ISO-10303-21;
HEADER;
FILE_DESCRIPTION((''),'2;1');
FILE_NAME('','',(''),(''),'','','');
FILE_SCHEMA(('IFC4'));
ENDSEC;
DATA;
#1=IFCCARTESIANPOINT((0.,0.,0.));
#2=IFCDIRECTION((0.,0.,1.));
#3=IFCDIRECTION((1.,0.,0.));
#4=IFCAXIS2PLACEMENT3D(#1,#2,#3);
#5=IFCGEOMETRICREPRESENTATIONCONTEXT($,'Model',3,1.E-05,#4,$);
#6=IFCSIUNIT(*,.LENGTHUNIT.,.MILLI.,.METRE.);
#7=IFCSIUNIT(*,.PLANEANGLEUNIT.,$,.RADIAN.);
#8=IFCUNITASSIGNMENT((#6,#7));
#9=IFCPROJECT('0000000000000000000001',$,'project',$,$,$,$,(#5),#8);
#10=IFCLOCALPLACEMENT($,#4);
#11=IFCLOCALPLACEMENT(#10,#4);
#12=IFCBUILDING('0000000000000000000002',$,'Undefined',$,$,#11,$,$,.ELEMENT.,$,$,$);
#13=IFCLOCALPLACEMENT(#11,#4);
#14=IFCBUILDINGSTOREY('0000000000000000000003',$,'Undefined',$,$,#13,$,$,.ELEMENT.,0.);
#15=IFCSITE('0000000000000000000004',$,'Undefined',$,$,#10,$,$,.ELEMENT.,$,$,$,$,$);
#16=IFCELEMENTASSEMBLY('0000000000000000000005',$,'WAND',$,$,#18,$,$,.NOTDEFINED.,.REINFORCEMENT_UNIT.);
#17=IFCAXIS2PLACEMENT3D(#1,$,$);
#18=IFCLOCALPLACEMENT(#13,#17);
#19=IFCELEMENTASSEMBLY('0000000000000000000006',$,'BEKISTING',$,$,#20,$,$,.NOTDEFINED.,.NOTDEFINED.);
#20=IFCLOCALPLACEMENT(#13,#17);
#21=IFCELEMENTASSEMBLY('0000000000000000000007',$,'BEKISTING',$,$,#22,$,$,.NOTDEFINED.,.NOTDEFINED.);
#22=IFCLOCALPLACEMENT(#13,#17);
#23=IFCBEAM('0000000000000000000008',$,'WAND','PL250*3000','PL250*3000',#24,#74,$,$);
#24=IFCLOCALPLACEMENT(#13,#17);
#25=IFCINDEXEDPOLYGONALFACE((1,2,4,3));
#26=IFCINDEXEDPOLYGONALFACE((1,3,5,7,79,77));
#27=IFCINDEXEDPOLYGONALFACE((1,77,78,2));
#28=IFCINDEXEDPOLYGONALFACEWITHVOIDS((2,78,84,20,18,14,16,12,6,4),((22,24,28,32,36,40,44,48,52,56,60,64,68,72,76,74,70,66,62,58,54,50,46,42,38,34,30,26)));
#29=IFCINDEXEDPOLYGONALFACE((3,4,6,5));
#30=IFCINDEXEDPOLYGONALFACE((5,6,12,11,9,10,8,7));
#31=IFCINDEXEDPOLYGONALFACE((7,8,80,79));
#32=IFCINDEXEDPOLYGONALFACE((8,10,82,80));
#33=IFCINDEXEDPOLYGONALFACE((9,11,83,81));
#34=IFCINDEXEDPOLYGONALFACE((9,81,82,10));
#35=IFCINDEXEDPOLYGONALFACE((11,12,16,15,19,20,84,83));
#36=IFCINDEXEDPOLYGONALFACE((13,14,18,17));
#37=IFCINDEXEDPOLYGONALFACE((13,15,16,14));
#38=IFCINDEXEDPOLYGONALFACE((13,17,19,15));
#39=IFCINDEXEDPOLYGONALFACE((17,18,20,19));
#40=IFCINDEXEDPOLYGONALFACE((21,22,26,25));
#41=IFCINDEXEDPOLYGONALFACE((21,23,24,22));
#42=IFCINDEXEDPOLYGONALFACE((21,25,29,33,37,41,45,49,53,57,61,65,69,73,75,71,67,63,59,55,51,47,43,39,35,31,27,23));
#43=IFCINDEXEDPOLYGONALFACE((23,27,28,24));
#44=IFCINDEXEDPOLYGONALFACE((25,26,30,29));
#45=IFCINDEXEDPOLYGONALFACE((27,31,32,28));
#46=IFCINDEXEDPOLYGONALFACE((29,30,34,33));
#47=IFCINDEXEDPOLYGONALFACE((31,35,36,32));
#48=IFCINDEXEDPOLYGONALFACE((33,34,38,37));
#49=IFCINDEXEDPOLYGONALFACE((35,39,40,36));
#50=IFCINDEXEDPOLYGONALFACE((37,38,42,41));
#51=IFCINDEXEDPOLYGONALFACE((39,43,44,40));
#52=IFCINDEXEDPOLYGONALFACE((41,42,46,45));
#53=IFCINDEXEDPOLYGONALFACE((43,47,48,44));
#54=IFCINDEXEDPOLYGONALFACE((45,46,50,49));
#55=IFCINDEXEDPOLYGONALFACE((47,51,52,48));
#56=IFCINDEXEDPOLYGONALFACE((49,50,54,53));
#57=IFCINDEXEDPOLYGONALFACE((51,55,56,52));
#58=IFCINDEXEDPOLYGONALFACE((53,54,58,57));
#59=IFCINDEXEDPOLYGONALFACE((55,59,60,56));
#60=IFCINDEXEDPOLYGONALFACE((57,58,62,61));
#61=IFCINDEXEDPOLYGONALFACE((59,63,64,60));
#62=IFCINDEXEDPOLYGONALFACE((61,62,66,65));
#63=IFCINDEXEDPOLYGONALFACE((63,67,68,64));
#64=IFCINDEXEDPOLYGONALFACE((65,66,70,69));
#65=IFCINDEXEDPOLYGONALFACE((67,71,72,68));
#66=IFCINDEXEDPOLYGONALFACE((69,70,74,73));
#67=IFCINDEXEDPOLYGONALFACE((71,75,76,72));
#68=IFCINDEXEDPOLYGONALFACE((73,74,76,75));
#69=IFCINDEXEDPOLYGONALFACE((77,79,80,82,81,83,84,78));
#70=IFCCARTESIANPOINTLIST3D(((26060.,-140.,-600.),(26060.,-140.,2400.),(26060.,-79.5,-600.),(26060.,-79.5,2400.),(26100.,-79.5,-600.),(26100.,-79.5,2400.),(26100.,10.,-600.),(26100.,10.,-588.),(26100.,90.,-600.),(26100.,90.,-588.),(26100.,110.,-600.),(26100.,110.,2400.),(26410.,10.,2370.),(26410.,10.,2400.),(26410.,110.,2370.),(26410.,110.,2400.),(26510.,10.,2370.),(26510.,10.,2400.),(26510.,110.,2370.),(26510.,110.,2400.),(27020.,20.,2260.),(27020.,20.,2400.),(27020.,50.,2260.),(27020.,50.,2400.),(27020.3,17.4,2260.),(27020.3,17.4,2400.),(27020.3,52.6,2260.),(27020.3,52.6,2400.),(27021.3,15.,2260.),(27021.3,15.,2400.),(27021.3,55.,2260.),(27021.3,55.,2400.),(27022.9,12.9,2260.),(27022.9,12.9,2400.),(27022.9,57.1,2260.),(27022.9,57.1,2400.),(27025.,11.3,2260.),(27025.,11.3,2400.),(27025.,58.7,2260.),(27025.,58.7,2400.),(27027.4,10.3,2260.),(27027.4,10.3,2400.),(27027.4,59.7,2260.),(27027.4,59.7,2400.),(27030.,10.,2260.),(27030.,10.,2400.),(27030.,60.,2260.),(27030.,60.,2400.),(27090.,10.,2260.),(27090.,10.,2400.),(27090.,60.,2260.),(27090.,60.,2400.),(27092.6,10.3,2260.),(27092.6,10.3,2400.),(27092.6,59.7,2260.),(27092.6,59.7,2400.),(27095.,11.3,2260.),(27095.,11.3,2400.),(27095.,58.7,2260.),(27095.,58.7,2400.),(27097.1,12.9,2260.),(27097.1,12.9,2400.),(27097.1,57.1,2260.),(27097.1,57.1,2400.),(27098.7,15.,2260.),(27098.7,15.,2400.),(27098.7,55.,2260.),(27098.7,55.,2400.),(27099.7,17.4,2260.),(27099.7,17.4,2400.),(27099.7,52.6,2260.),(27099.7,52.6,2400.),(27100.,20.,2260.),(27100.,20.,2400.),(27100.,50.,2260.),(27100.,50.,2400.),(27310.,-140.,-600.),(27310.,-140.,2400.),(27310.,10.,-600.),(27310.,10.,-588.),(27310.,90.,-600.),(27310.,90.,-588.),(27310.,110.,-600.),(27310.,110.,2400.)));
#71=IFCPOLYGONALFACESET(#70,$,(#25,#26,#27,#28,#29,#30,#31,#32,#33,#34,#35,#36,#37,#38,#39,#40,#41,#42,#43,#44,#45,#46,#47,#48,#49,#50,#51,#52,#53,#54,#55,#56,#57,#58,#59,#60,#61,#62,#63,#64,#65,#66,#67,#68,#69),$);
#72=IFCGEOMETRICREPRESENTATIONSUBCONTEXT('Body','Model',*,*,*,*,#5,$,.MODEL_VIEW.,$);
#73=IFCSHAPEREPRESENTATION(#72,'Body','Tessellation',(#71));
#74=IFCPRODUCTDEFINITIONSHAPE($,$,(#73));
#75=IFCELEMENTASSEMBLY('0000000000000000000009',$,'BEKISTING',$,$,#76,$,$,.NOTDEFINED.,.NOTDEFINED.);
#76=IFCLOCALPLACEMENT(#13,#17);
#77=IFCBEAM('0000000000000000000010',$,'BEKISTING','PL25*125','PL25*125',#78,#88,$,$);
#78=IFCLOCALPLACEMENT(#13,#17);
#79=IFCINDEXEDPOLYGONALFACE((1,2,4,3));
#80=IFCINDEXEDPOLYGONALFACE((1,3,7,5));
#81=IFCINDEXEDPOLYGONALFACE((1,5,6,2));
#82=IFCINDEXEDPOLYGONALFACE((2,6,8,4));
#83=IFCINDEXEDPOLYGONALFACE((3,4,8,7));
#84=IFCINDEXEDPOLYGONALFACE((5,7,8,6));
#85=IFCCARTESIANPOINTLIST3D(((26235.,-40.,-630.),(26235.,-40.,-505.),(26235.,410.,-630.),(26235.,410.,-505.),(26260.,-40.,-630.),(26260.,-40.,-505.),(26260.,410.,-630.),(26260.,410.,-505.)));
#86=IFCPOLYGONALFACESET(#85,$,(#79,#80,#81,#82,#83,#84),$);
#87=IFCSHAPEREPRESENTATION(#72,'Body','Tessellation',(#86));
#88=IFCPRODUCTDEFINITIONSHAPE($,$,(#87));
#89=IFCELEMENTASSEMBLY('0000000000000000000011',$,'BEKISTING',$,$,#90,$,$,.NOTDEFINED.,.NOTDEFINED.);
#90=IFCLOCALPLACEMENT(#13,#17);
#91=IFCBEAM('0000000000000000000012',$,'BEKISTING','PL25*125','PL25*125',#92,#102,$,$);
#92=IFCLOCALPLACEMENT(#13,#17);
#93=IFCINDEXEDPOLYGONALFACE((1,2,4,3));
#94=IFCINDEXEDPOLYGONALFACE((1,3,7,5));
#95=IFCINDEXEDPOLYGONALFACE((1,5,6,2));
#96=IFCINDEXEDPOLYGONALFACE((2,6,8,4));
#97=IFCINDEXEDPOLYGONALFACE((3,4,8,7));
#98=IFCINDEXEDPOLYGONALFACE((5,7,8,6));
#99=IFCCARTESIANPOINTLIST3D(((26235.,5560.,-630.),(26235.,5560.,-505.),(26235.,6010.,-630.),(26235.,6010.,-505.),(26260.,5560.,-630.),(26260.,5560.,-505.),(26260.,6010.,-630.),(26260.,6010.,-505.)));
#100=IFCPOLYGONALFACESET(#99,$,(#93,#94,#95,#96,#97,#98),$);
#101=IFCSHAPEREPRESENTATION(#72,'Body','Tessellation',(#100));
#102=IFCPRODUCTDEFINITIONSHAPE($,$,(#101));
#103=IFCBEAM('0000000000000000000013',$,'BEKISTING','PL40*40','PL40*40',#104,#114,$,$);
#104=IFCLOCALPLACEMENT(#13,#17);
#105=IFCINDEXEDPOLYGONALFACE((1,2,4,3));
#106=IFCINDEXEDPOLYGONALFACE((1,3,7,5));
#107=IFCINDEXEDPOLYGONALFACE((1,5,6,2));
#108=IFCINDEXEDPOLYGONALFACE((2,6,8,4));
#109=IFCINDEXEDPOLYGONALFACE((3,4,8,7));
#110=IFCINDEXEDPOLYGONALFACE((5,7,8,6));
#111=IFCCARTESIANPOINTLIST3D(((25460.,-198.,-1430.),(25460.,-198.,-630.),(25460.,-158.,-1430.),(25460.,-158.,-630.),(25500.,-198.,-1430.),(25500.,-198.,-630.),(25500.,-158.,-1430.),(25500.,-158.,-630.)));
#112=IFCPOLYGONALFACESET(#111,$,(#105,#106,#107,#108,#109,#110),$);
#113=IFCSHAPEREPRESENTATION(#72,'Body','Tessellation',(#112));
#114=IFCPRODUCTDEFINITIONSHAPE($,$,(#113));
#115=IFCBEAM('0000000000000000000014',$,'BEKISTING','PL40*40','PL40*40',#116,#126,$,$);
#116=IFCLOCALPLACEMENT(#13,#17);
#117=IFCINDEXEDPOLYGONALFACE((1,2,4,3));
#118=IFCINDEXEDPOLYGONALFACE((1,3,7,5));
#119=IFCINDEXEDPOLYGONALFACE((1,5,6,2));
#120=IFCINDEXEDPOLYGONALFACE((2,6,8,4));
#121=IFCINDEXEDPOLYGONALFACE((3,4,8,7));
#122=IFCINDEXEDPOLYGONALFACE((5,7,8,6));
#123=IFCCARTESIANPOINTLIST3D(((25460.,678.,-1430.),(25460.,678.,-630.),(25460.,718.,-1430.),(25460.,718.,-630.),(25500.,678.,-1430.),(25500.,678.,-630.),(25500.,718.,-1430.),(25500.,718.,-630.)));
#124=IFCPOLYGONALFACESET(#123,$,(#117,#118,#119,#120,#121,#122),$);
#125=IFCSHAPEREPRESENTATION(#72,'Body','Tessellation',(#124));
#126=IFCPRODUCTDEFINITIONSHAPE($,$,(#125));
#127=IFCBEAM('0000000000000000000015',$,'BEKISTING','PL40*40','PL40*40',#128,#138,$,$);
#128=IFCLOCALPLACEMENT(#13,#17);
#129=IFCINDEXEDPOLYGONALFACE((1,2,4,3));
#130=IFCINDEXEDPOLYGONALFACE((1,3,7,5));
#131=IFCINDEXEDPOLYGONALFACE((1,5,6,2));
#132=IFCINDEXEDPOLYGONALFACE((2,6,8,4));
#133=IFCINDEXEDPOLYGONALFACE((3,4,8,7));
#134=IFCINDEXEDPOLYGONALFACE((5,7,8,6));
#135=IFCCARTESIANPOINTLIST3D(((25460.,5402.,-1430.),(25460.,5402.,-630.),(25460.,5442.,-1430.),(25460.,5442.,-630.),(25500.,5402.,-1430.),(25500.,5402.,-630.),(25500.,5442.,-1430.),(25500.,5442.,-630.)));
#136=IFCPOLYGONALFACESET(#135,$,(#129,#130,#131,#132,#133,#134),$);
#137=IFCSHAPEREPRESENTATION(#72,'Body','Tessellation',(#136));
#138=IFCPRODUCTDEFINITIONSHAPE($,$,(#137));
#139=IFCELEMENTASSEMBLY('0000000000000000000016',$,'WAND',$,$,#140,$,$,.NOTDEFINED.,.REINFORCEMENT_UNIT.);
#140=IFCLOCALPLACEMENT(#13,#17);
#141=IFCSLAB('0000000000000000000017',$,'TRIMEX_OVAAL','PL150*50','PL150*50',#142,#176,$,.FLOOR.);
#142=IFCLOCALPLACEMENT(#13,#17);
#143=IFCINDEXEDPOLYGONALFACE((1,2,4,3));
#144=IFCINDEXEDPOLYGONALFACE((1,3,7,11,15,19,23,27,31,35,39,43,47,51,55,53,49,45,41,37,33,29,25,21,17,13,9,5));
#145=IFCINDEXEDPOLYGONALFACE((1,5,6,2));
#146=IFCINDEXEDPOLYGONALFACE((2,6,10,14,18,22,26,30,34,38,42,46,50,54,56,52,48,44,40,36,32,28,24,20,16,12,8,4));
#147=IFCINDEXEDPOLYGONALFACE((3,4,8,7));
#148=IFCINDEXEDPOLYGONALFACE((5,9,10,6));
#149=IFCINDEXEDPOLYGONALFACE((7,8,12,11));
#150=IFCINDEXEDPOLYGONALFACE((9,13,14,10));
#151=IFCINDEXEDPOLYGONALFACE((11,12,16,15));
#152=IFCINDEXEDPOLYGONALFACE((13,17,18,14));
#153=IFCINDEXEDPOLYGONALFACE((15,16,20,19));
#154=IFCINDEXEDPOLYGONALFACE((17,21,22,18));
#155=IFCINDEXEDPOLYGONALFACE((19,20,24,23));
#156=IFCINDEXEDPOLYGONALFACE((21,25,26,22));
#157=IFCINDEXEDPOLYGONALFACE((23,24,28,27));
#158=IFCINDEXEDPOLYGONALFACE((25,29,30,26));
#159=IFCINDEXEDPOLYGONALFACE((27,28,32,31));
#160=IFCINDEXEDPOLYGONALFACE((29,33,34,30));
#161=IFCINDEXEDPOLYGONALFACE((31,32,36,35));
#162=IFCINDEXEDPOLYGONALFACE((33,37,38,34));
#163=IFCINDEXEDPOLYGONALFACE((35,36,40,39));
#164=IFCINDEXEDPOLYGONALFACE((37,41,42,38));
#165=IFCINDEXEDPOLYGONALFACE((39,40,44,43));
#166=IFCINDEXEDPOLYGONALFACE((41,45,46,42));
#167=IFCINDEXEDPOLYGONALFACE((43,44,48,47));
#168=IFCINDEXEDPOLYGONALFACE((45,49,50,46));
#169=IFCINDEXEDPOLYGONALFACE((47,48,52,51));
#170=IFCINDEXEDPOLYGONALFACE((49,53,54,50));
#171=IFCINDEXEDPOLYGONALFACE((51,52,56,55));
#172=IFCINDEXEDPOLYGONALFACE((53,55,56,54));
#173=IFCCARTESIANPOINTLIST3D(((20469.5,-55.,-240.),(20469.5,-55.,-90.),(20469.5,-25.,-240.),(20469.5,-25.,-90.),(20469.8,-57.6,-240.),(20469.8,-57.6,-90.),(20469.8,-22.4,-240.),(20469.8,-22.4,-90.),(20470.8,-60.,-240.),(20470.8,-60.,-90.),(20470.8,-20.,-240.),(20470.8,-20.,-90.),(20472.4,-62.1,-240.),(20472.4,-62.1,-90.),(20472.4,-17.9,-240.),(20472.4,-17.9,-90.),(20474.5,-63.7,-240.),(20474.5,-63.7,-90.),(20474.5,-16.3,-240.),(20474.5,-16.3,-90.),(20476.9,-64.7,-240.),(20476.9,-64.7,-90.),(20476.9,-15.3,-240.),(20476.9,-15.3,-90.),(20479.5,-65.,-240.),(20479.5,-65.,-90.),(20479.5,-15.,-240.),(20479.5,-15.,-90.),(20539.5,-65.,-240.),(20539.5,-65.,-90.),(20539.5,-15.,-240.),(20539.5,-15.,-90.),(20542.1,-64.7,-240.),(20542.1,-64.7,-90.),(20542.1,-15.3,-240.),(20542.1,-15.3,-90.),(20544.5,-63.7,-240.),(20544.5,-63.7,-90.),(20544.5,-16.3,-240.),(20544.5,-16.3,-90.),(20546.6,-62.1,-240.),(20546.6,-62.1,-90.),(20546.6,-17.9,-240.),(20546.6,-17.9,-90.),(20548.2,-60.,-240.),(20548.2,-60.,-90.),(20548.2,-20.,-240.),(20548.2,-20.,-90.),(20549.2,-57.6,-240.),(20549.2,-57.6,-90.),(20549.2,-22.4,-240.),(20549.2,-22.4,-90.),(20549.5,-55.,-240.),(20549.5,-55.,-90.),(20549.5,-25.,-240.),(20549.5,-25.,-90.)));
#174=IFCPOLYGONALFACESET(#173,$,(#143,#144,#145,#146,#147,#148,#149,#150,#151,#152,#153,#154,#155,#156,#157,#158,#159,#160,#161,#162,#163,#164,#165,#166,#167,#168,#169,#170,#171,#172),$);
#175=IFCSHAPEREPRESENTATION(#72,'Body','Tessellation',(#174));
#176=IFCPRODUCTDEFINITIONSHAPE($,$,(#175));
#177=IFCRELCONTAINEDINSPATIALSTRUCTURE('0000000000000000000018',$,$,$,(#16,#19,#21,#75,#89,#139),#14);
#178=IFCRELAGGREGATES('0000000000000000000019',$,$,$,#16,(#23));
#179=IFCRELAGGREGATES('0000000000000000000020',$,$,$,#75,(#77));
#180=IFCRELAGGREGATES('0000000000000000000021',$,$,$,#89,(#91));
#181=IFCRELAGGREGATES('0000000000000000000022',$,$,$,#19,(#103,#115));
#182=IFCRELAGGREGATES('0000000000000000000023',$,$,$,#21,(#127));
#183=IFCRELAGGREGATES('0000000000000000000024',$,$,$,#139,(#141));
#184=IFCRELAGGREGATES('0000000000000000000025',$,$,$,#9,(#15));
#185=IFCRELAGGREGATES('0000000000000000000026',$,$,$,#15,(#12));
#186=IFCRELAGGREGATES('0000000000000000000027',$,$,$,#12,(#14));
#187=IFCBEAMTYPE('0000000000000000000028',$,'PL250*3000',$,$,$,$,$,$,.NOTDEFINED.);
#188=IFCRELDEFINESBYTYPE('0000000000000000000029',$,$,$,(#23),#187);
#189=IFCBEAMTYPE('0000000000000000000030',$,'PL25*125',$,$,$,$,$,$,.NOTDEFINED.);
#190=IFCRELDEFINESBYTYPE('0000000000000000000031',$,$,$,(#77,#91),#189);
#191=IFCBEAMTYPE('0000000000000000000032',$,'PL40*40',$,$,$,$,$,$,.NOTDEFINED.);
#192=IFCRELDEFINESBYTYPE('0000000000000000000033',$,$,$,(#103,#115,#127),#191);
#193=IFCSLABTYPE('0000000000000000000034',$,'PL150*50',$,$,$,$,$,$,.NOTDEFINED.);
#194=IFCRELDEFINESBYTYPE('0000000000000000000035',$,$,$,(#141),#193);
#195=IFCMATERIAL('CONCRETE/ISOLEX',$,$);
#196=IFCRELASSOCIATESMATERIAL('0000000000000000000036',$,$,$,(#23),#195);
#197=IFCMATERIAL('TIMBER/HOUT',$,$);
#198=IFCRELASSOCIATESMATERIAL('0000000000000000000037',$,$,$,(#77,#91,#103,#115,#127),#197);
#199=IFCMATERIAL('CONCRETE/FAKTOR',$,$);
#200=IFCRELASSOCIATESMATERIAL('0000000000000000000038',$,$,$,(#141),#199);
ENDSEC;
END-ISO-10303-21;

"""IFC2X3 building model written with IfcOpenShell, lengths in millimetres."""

from ifc_helpers import new_model, si_unit, frame, frame_2d, origin_with_axes, place, context, subcontext, project, spatial, polyline, circle_curve, parameter, trimmed, segment, composite_curve, rectangle, outline, extrude, boolean, material, type_object, element, aggregate, save


model = new_model("IFC2X3")

# Units and contexts
model_context = context("Model", 3, precision=1e-05, world=origin_with_axes())
body_context = subcontext(model_context, "Body", "Model", "MODEL_VIEW")
ifc_project = project(units=[si_unit("LENGTHUNIT", "METRE", prefix="MILLI"), si_unit("PLANEANGLEUNIT", "RADIAN")], contexts=[model_context])

# Site, building, storey
site_placement = place(None, origin_with_axes())
site = spatial("IfcSite", under=ifc_project, at=site_placement, Name="Undefined", CompositionType="ELEMENT")
building_placement = place(site_placement, origin_with_axes())
building = spatial("IfcBuilding", under=site, at=building_placement, Name="Undefined", CompositionType="ELEMENT")
storey_placement = place(building_placement, origin_with_axes())
storey = spatial("IfcBuildingStorey", under=building, at=storey_placement, Name="Undefined", CompositionType="ELEMENT", Elevation=0.0)

# Shared definitions
ifc_material_1 = material(Name="CONCRETE/FAKTOR")

# Element assembly
assembly_1_placement = place(storey_placement, origin_with_axes())
assembly_1 = element("IfcElementAssembly", 1, at=assembly_1_placement, inside=storey, Name="WAND", AssemblyPlace="NOTDEFINED", PredefinedType="REINFORCEMENT_UNIT")
ifc_material_2 = material(Name="CONCRETE/ISOLEX")

# Element assemblies
assembly_2_placement = place(storey_placement, origin_with_axes())
assembly_2 = element("IfcElementAssembly", 2, at=assembly_2_placement, inside=storey, Name="BEKISTING", AssemblyPlace="NOTDEFINED", PredefinedType="NOTDEFINED")
ifc_material_3 = material(Name="TIMBER/HOUT")
assembly_3_placement = place(storey_placement, origin_with_axes())
assembly_3 = element("IfcElementAssembly", 3, at=assembly_3_placement, inside=storey, Name="BEKISTING", AssemblyPlace="NOTDEFINED", PredefinedType="NOTDEFINED")

# Beam
beam_type_1 = type_object("IfcBeamType", Name="PL250*3000", PredefinedType="NOTDEFINED")
beam_1_placement = place(assembly_1_placement, frame((26060.0, -15.0, 900.0), z_axis=(0.0, 0.0, 1.0), x_axis=(1.0, 0.0, 0.0)))
beam_1 = element("IfcBeam", 4, at=beam_1_placement, type_object=beam_type_1, material=ifc_material_2, Name="WAND", Description="PL250*3000", ObjectType="PL250*3000", context=body_context, shape_type="CSG", body=[
    boolean("DIFFERENCE", boolean("DIFFERENCE", boolean("DIFFERENCE", boolean("DIFFERENCE", extrude(rectangle(XDim=250.0, YDim=3000.0, at=frame_2d((0.0, 0.0), x_axis=(1.0, 0.0))), frame((1250.0, 0.0, 0.0), z_axis=(-1.0, 0.0, 0.0), x_axis=(0.0, -1.0, 0.0)), (0.0, 0.0, 1.0), 1250.0), extrude(rectangle(XDim=40.0, YDim=190.0, at=frame_2d((0.0, 0.0), x_axis=(1.0, 0.0))), frame((20.0, 30.5, 1500.0), z_axis=(0.0, 0.0, -1.0), x_axis=(1.0, 0.0, 0.0)), (0.0, 0.0, 1.0), 3000.0)), extrude(outline(composite_curve([segment(trimmed(circle_curve(frame_2d((10.0, 10.0), x_axis=(-1.0, 0.0)), 10.0), [parameter(0.0)], [parameter(1.570796)], True, "PARAMETER"), True, "CONTINUOUS"), segment(polyline([(10.0, 0.0), (40.0, 0.0)]), True, "CONTINUOUS"), segment(trimmed(circle_curve(frame_2d((40.0, 10.0), x_axis=(0.0, -1.0)), 10.0), [parameter(0.0)], [parameter(1.570796)], True, "PARAMETER"), True, "CONTINUOUS"), segment(polyline([(50.0, 10.0), (50.0, 70.0)]), True, "CONTINUOUS"), segment(trimmed(circle_curve(frame_2d((40.0, 70.0), x_axis=(1.0, 0.0)), 10.0), [parameter(0.0)], [parameter(1.570796)], True, "PARAMETER"), True, "CONTINUOUS"), segment(polyline([(40.0, 80.0), (10.0, 80.0)]), True, "CONTINUOUS"), segment(trimmed(circle_curve(frame_2d((10.0, 70.0), x_axis=(0.0, 1.0)), 10.0), [parameter(0.0)], [parameter(1.570796)], True, "PARAMETER"), True, "CONTINUOUS"), segment(polyline([(0.0, 70.0), (0.0, 10.0)]), True, "CONTINUOUS")], self_intersect=True)), frame((960.0, 75.0, 1360.0), z_axis=(0.0, 0.0, 1.0), x_axis=(0.0, -1.0, 0.0)), (0.0, 0.0, 1.0), 150.0)), extrude(rectangle(XDim=100.0, YDim=100.0, at=frame_2d((0.0, 0.0), x_axis=(1.0, 0.0))), frame((400.0, 75.0, 1470.0), z_axis=(0.0, 0.0, 1.0), x_axis=(-1.0, 0.0, 0.0)), (0.0, 0.0, 1.0), 30.0)), extrude(rectangle(XDim=12.0, YDim=80.0, at=frame_2d((0.0, 0.0), x_axis=(1.0, 0.0))), frame((1250.0, 65.0, -1494.0), z_axis=(-1.0, 0.0, 0.0), x_axis=(0.0, 0.0, -1.0)), (0.0, 0.0, 1.0), 1250.0)),
])
aggregate(assembly_1, [beam_1])

# Element assemblies, beams
assembly_4_placement = place(storey_placement, origin_with_axes())
assembly_4 = element("IfcElementAssembly", 5, at=assembly_4_placement, inside=storey, Name="BEKISTING", AssemblyPlace="NOTDEFINED", PredefinedType="NOTDEFINED")
beam_type_2 = type_object("IfcBeamType", Name="PL25*125", PredefinedType="NOTDEFINED")
beam_2_placement = place(assembly_4_placement, frame((26247.5, -40.0, -567.5), z_axis=(0.0, 0.0, -1.0), x_axis=(0.0, 1.0, 0.0)))
beam_2 = element("IfcBeam", 6, at=beam_2_placement, type_object=beam_type_2, material=ifc_material_3, Name="BEKISTING", Description="PL25*125", ObjectType="PL25*125", context=body_context, shape_type="SweptSolid", body=[
    extrude(rectangle(XDim=25.0, YDim=125.0, at=frame_2d((0.0, 0.0), x_axis=(1.0, 0.0))), frame((450.0, 0.0, 0.0), z_axis=(-1.0, 0.0, 0.0), x_axis=(0.0, -1.0, 0.0)), (0.0, 0.0, 1.0), 450.0),
])
aggregate(assembly_4, [beam_2])
assembly_5_placement = place(storey_placement, origin_with_axes())
assembly_5 = element("IfcElementAssembly", 7, at=assembly_5_placement, inside=storey, Name="BEKISTING", AssemblyPlace="NOTDEFINED", PredefinedType="NOTDEFINED")
beam_3_placement = place(assembly_5_placement, frame((26247.5, 5560.0, -567.5), z_axis=(0.0, 0.0, -1.0), x_axis=(0.0, 1.0, 0.0)))
beam_3 = element("IfcBeam", 8, at=beam_3_placement, type_object=beam_type_2, material=ifc_material_3, Name="BEKISTING", Description="PL25*125", ObjectType="PL25*125", context=body_context, shape_type="SweptSolid", body=[
    extrude(rectangle(XDim=25.0, YDim=125.0, at=frame_2d((0.0, 0.0), x_axis=(1.0, 0.0))), frame((450.0, 0.0, 0.0), z_axis=(-1.0, 0.0, 0.0), x_axis=(0.0, -1.0, 0.0)), (0.0, 0.0, 1.0), 450.0),
])
aggregate(assembly_5, [beam_3])

# Beams
beam_type_3 = type_object("IfcBeamType", Name="PL40*40", PredefinedType="NOTDEFINED")
beam_4_placement = place(assembly_2_placement, frame((25480.0, -178.0, -1430.0), z_axis=(0.0, 1.0, 0.0), x_axis=(0.0, 0.0, 1.0)))
beam_4 = element("IfcBeam", 9, at=beam_4_placement, type_object=beam_type_3, material=ifc_material_3, Name="BEKISTING", Description="PL40*40", ObjectType="PL40*40", context=body_context, shape_type="SweptSolid", body=[
    extrude(rectangle(XDim=40.0, YDim=40.0, at=frame_2d((0.0, 0.0), x_axis=(1.0, 0.0))), frame((800.0, 0.0, 0.0), z_axis=(-1.0, 0.0, 0.0), x_axis=(0.0, -1.0, 0.0)), (0.0, 0.0, 1.0), 800.0),
])
beam_5_placement = place(assembly_2_placement, frame((25480.0, 698.0, -1430.0), z_axis=(0.0, 1.0, 0.0), x_axis=(0.0, 0.0, 1.0)))
beam_5 = element("IfcBeam", 10, at=beam_5_placement, type_object=beam_type_3, material=ifc_material_3, Name="BEKISTING", Description="PL40*40", ObjectType="PL40*40", context=body_context, shape_type="SweptSolid", body=[
    extrude(rectangle(XDim=40.0, YDim=40.0, at=frame_2d((0.0, 0.0), x_axis=(1.0, 0.0))), frame((800.0, 0.0, 0.0), z_axis=(-1.0, 0.0, 0.0), x_axis=(0.0, -1.0, 0.0)), (0.0, 0.0, 1.0), 800.0),
])
aggregate(assembly_2, [beam_4, beam_5])
beam_6_placement = place(assembly_3_placement, frame((25480.0, 5422.0, -1430.0), z_axis=(0.0, 1.0, 0.0), x_axis=(0.0, 0.0, 1.0)))
beam_6 = element("IfcBeam", 11, at=beam_6_placement, type_object=beam_type_3, material=ifc_material_3, Name="BEKISTING", Description="PL40*40", ObjectType="PL40*40", context=body_context, shape_type="SweptSolid", body=[
    extrude(rectangle(XDim=40.0, YDim=40.0, at=frame_2d((0.0, 0.0), x_axis=(1.0, 0.0))), frame((800.0, 0.0, 0.0), z_axis=(-1.0, 0.0, 0.0), x_axis=(0.0, -1.0, 0.0)), (0.0, 0.0, 1.0), 800.0),
])
aggregate(assembly_3, [beam_6])

# Element assembly, slab
assembly_6_placement = place(storey_placement, origin_with_axes())
assembly_6 = element("IfcElementAssembly", 12, at=assembly_6_placement, inside=storey, Name="WAND", AssemblyPlace="NOTDEFINED", PredefinedType="REINFORCEMENT_UNIT")
slab_type = type_object("IfcSlabType", Name="PL150*50", PredefinedType="NOTDEFINED")
slab_1_placement = place(assembly_6_placement, frame((20549.5, -65.0, -165.0), z_axis=(0.0, 0.0, 1.0), x_axis=(0.0, 1.0, 0.0)))
slab_1 = element("IfcSlab", 13, at=slab_1_placement, type_object=slab_type, material=ifc_material_1, Name="TRIMEX_OVAAL", Description="PL150*50", ObjectType="PL150*50", PredefinedType="FLOOR", context=body_context, shape_type="SweptSolid", body=[
    extrude(outline(composite_curve([segment(trimmed(circle_curve(frame_2d((10.0, 10.0), x_axis=(-1.0, 0.0)), 10.0), [parameter(0.0)], [parameter(1.570796)], True, "PARAMETER"), True, "CONTINUOUS"), segment(polyline([(10.0, 0.0), (40.0, 0.0)]), True, "CONTINUOUS"), segment(trimmed(circle_curve(frame_2d((40.0, 10.0), x_axis=(0.0, -1.0)), 10.0), [parameter(0.0)], [parameter(1.570796)], True, "PARAMETER"), True, "CONTINUOUS"), segment(polyline([(50.0, 10.0), (50.0, 70.0)]), True, "CONTINUOUS"), segment(trimmed(circle_curve(frame_2d((40.0, 70.0), x_axis=(1.0, 0.0)), 10.0), [parameter(0.0)], [parameter(1.570796)], True, "PARAMETER"), True, "CONTINUOUS"), segment(polyline([(40.0, 80.0), (10.0, 80.0)]), True, "CONTINUOUS"), segment(trimmed(circle_curve(frame_2d((10.0, 70.0), x_axis=(0.0, 1.0)), 10.0), [parameter(0.0)], [parameter(1.570796)], True, "PARAMETER"), True, "CONTINUOUS"), segment(polyline([(0.0, 70.0), (0.0, 10.0)]), True, "CONTINUOUS")], self_intersect=True)), frame((0.0, 0.0, -75.0), z_axis=(0.0, 0.0, 1.0), x_axis=(1.0, 0.0, 0.0)), (0.0, 0.0, 1.0), 150.0),
])

aggregate(assembly_6, [slab_1])

save(model, "model.ifc")
